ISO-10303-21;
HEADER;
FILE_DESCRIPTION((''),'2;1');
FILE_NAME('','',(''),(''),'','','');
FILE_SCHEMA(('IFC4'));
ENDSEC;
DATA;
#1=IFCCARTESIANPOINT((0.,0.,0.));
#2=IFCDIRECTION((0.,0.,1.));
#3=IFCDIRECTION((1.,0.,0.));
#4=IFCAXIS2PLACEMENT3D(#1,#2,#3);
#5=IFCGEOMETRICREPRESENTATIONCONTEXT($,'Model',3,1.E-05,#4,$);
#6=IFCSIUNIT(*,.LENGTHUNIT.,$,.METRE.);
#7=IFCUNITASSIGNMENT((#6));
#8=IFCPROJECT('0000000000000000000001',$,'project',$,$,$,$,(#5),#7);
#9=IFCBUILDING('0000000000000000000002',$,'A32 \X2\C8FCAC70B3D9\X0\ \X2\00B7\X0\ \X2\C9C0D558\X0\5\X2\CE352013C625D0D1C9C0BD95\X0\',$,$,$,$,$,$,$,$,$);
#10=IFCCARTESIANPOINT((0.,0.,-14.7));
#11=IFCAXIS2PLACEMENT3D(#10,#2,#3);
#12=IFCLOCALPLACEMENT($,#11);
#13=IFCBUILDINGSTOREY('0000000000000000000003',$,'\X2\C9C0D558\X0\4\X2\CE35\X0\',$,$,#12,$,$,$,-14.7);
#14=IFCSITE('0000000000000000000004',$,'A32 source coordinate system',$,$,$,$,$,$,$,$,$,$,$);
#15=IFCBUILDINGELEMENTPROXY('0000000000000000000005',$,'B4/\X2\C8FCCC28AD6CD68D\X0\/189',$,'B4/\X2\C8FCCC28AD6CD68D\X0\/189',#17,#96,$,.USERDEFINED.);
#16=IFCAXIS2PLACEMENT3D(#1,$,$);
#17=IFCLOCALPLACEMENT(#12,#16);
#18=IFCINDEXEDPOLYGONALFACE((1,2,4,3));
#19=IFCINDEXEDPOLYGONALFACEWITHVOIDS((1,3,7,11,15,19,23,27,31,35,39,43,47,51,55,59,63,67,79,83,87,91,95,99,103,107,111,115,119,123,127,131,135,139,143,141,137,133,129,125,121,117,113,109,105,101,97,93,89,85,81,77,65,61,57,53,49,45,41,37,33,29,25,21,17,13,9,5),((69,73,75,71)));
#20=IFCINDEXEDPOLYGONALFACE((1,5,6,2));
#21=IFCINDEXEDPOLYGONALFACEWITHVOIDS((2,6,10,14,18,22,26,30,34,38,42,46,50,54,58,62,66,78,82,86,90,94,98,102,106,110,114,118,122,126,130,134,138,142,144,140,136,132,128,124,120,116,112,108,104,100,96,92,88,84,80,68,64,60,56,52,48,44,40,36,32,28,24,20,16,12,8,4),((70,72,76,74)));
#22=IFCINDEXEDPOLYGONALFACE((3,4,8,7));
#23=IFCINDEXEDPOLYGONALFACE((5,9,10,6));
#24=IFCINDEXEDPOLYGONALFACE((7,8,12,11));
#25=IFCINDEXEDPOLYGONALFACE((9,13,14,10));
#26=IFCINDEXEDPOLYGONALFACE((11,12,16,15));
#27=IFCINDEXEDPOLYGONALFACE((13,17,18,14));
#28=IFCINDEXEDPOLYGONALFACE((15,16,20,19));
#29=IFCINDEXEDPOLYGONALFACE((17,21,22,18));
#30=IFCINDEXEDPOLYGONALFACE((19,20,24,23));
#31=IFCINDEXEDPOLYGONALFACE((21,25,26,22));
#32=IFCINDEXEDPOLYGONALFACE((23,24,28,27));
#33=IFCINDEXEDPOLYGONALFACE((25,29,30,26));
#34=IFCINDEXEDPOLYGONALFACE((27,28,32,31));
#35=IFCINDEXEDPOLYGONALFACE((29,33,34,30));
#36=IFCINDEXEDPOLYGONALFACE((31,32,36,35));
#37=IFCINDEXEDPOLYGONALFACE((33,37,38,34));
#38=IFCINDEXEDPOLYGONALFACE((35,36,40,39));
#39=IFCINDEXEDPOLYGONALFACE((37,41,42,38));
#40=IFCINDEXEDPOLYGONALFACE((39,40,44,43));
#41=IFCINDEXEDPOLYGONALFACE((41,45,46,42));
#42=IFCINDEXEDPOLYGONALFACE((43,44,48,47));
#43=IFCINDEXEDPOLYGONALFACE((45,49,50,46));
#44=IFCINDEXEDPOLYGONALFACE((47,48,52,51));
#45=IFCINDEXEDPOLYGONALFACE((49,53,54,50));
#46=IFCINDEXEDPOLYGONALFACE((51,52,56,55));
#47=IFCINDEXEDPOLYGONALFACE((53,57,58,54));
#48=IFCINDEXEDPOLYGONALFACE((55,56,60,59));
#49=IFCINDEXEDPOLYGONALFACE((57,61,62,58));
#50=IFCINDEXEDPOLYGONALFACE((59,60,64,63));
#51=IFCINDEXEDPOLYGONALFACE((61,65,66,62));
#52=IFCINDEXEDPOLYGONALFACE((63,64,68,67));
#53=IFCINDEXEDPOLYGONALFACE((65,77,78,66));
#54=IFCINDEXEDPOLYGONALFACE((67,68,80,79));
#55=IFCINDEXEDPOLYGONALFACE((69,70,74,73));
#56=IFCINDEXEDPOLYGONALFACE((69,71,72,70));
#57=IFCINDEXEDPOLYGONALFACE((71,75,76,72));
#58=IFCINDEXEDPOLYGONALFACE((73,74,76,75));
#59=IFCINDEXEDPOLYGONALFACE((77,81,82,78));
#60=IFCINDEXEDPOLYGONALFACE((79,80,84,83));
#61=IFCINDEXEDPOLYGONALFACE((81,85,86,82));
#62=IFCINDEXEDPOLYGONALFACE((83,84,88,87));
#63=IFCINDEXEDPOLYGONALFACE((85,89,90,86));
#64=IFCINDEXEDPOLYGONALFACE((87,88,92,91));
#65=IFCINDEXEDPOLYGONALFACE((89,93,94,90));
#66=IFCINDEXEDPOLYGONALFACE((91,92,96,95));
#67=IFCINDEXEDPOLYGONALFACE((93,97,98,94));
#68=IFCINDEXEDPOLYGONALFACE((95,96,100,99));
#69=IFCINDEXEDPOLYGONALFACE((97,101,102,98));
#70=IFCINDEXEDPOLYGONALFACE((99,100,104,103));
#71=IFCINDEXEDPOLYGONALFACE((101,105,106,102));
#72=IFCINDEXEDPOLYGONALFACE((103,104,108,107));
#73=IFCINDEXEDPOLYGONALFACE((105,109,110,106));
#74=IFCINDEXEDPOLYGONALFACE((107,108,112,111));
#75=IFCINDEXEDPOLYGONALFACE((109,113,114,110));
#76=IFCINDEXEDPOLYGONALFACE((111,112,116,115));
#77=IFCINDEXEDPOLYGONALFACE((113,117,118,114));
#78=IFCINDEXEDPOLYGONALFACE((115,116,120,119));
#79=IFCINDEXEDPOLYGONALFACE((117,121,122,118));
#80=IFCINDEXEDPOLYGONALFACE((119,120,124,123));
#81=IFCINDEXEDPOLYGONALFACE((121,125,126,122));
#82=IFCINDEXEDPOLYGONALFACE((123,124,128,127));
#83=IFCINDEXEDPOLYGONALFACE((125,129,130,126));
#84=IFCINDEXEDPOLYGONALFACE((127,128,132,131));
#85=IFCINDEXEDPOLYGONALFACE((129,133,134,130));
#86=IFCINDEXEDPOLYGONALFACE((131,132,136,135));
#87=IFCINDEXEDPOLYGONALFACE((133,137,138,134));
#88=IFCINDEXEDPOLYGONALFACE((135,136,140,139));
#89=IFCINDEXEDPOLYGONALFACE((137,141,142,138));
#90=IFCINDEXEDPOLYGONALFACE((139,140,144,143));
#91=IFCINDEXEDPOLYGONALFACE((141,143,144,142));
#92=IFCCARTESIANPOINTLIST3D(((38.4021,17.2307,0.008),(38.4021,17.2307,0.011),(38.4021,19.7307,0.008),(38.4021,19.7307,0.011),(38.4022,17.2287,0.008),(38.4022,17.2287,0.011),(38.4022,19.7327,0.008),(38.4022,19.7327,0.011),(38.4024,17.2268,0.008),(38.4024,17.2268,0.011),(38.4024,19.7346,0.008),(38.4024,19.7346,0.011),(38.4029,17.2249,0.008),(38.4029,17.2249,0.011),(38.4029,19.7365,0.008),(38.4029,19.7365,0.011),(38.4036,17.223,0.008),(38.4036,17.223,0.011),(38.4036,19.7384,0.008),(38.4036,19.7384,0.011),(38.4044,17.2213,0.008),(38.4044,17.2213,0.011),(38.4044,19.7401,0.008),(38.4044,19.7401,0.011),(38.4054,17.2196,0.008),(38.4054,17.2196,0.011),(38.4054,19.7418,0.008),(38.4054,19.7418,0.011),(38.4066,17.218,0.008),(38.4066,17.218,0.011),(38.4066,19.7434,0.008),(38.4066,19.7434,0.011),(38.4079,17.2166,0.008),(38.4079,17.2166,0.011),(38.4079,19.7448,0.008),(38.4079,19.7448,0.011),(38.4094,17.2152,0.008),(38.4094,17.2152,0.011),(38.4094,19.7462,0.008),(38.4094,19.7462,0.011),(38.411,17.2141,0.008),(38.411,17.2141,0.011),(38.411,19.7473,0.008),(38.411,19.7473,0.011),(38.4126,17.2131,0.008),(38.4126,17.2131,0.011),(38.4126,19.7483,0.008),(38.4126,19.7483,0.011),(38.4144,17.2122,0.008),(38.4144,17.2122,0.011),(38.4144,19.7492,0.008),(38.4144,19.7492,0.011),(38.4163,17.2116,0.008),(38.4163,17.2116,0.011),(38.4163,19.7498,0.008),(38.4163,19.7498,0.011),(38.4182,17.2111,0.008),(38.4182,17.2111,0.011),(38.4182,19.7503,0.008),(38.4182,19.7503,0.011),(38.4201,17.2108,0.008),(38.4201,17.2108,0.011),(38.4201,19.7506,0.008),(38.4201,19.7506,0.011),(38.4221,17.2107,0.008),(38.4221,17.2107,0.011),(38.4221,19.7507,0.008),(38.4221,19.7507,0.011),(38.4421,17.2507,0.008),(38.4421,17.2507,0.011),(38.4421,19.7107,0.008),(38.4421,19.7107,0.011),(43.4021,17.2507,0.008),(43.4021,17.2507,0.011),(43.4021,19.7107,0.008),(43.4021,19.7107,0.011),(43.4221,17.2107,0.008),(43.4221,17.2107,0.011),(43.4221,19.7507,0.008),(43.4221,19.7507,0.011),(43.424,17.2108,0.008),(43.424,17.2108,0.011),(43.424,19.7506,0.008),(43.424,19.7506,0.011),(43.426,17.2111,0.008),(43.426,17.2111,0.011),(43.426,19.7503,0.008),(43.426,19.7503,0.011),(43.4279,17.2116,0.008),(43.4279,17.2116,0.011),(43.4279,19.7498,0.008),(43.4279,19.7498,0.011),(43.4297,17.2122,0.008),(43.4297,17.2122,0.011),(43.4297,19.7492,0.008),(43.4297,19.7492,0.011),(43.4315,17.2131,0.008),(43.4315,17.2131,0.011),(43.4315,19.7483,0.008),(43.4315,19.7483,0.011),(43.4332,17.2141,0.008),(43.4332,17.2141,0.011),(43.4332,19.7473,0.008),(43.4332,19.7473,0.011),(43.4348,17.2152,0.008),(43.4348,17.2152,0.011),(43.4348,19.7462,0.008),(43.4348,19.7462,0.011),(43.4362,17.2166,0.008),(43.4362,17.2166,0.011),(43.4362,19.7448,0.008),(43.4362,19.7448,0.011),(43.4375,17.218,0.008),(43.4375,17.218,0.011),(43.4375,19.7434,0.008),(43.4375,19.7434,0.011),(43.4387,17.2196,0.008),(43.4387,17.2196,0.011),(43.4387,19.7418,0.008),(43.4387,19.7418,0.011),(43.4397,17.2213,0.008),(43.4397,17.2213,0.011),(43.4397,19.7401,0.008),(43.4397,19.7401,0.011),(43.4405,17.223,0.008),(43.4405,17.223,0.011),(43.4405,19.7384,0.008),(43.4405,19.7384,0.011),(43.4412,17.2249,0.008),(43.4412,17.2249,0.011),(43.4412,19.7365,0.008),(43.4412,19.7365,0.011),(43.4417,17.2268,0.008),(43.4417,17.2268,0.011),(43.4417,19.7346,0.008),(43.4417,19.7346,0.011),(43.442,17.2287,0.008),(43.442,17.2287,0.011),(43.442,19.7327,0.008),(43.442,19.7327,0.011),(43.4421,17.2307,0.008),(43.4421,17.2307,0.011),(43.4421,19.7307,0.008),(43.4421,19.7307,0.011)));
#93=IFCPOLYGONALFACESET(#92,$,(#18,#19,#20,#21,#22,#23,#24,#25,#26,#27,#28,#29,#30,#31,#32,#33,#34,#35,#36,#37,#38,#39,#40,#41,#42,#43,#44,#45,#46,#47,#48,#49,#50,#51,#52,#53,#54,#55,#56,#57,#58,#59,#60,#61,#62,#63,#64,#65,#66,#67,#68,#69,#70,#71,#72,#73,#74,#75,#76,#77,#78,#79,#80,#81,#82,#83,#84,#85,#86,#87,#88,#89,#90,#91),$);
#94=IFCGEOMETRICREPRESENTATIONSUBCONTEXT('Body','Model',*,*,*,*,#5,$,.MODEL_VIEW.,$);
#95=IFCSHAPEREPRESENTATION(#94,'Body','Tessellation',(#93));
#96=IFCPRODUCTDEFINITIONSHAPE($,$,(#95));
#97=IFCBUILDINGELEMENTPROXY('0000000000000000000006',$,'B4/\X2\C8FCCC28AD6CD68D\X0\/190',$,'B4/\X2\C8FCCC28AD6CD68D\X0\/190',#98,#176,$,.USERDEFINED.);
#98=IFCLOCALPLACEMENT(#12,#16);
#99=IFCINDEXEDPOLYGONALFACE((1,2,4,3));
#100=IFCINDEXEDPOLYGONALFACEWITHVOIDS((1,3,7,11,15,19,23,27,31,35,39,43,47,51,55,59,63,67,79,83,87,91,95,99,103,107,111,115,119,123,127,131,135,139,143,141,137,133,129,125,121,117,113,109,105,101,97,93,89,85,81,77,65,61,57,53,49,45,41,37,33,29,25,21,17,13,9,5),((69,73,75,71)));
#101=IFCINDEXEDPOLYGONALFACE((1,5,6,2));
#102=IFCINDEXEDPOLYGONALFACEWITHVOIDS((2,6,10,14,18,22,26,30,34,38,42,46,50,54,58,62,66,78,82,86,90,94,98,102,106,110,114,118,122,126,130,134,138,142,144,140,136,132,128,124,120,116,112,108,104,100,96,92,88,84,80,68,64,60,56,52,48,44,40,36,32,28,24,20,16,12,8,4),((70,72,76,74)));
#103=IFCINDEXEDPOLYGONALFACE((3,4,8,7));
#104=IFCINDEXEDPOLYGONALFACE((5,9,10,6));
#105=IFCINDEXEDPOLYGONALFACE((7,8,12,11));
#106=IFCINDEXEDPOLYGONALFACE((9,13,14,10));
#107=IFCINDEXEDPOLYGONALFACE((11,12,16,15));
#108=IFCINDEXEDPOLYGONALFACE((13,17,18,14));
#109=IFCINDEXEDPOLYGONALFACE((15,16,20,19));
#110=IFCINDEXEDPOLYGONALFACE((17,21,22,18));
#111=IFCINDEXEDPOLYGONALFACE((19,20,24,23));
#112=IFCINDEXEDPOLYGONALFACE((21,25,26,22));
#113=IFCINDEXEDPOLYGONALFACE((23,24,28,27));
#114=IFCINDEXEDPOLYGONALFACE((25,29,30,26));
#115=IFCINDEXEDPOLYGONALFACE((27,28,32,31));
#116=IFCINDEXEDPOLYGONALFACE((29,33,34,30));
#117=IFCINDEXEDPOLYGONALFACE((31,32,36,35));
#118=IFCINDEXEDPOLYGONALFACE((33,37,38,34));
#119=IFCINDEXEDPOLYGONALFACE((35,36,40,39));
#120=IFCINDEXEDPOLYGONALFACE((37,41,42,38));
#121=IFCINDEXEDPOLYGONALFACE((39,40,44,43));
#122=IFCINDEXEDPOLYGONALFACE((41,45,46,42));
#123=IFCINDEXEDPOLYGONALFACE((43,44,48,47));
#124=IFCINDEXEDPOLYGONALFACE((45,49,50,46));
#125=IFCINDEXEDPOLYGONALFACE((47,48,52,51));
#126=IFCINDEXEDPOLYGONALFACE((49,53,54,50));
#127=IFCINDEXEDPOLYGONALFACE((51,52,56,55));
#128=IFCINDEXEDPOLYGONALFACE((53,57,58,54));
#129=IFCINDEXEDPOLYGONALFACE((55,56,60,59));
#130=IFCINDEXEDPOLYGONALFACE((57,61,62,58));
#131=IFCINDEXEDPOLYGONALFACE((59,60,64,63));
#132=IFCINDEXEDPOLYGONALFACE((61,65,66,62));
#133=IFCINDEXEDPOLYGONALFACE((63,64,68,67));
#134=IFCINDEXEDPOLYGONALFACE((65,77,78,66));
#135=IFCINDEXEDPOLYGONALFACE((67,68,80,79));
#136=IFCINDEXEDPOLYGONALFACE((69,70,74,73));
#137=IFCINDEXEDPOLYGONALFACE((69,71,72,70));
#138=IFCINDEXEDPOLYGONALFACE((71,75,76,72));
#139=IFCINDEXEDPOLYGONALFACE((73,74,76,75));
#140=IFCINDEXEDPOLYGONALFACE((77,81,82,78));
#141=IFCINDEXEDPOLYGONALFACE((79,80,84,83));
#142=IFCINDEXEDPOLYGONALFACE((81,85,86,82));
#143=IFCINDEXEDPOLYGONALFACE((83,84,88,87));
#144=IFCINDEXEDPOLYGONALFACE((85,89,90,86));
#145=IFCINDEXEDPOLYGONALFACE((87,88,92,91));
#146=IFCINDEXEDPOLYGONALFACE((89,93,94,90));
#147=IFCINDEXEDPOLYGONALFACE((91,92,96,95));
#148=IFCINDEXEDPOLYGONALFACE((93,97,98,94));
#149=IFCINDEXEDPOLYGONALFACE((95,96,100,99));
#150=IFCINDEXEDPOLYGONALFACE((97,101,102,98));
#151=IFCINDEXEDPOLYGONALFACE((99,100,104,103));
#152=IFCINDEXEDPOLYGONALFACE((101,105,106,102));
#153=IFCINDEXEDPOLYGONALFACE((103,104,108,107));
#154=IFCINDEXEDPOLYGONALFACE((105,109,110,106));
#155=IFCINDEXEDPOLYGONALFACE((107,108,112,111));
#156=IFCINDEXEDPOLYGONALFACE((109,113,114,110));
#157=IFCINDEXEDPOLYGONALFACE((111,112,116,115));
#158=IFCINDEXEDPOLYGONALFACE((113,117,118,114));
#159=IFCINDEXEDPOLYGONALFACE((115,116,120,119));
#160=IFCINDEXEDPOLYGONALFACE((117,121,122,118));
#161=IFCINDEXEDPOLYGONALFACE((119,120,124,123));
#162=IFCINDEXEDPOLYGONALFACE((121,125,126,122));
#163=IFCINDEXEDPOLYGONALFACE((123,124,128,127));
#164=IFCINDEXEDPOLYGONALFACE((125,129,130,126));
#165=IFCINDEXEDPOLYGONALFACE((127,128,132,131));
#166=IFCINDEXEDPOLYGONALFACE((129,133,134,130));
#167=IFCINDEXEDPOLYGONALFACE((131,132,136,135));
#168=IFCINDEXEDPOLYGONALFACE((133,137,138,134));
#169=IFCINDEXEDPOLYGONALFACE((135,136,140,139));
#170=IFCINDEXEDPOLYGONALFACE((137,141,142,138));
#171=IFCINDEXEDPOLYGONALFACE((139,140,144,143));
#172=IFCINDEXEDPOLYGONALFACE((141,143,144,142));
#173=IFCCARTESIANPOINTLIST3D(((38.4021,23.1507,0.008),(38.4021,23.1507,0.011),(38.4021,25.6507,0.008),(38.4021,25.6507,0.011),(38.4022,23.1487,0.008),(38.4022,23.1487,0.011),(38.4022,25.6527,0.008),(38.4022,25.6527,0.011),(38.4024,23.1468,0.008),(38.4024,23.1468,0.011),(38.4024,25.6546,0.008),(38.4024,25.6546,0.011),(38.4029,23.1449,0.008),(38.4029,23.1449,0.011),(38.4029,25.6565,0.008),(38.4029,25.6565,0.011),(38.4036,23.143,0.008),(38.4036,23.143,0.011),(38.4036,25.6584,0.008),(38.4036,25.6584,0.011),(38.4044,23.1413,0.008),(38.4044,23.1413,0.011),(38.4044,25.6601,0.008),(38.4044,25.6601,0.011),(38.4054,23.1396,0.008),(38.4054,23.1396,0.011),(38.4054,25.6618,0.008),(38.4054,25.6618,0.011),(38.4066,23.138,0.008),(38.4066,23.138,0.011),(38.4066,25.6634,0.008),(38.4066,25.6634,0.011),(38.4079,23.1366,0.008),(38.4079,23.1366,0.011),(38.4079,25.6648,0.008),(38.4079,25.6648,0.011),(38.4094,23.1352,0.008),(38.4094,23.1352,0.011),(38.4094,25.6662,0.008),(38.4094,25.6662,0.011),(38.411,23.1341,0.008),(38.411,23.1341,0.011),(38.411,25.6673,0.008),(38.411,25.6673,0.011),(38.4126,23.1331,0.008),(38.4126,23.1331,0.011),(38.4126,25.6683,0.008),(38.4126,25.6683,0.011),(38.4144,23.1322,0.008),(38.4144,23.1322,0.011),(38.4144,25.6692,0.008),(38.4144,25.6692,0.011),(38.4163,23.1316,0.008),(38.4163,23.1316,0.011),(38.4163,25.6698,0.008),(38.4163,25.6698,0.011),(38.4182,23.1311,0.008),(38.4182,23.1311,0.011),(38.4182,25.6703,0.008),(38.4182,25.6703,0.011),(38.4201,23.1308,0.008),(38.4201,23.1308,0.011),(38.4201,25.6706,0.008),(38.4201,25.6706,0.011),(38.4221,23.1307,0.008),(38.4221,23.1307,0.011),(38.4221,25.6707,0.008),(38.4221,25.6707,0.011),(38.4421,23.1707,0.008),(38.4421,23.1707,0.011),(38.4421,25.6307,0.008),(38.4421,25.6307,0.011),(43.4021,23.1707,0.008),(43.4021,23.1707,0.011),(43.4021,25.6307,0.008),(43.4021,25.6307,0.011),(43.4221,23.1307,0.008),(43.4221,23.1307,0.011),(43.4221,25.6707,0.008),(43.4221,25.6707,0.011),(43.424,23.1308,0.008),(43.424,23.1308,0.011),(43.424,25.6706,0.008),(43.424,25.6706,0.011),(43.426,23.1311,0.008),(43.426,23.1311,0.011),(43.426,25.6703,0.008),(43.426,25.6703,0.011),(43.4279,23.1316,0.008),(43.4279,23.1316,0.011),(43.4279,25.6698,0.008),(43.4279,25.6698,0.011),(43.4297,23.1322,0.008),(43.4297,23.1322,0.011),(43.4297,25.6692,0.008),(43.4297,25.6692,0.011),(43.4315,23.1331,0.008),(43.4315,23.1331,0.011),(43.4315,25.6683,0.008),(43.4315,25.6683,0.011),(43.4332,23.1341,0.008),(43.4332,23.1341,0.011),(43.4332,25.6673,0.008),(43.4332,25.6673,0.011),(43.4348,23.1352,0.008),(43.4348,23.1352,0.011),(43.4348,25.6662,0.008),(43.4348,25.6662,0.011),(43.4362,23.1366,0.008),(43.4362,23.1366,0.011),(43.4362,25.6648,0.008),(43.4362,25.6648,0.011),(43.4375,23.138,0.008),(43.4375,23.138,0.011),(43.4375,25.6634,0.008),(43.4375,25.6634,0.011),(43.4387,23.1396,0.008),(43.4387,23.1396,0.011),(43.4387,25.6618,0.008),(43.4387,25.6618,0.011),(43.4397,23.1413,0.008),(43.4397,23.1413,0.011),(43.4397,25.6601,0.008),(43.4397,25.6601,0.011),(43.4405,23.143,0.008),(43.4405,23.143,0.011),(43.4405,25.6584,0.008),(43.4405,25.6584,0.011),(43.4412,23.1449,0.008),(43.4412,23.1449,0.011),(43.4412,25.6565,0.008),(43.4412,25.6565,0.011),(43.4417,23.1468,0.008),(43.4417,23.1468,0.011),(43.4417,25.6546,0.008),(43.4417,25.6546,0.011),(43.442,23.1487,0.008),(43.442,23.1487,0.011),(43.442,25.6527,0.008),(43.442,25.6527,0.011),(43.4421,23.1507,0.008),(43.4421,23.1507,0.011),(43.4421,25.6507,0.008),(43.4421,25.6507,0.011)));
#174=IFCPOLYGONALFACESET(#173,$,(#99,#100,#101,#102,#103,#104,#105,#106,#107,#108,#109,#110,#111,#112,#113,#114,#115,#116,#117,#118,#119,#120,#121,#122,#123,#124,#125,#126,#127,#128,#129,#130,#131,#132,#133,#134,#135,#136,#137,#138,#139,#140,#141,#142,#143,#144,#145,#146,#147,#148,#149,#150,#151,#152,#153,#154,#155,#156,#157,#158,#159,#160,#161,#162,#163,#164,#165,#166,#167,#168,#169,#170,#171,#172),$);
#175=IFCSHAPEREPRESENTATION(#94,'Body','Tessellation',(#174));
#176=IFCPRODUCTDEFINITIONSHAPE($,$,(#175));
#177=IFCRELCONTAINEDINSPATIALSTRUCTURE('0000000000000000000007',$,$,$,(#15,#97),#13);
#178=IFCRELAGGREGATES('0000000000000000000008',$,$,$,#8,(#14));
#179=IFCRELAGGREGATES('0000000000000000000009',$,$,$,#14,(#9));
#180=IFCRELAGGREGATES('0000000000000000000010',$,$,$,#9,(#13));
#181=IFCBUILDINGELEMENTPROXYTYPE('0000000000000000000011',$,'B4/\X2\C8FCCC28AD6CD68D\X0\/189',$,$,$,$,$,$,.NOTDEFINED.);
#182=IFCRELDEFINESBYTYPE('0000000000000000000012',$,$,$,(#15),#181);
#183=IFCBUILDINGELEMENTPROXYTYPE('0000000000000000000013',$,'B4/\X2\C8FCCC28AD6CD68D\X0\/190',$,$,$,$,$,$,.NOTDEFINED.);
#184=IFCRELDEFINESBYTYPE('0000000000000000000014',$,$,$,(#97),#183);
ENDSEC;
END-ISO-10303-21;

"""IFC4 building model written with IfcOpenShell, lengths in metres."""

from ifc_helpers import new_model, si_unit, frame, origin, origin_with_axes, place, context, subcontext, project, spatial, polyline, outline, extrude, source, transform, mapped, type_object, type_shapes, element, save


model = new_model("IFC4")

# Units and contexts
model_context = context("Model", 3, precision=1e-05, world=origin_with_axes())
body_context = subcontext(model_context, "Body", "Model", "MODEL_VIEW")
ifc_project = project(units=[si_unit("LENGTHUNIT", "METRE")], contexts=[model_context])

# Site, building, storey
site = spatial("IfcSite", under=ifc_project, Name="A32 source coordinate system")
building = spatial("IfcBuilding", under=site, Name="A32 주거동 · 지하5층–옥탑지붕")
storey_placement = place(None, frame((0.0, 0.0, -14.7), z_axis=(0.0, 0.0, 1.0), x_axis=(1.0, 0.0, 0.0)))
storey = spatial("IfcBuildingStorey", under=building, at=storey_placement, Name="지하4층", Elevation=-14.7)

# Building element proxies
building_element_proxy_type_1 = type_object("IfcBuildingElementProxyType", Name="B4/주차구획/189", PredefinedType="NOTDEFINED")
shared_shape_1 = source(origin(), body_context, "Body", "SweptSolid", [
    extrude(outline(polyline([(43.4221, 19.7507), (43.424, 19.7506), (43.426, 19.7503), (43.4279, 19.7498), (43.4297, 19.7492), (43.4315, 19.7483), (43.4332, 19.7473), (43.4348, 19.7462), (43.4362, 19.7448), (43.4375, 19.7434), (43.4387, 19.7418), (43.4397, 19.7401), (43.4405, 19.7384), (43.4412, 19.7365), (43.4417, 19.7346), (43.442, 19.7327), (43.4421, 19.7307), (43.4421, 17.2307), (43.442, 17.2287), (43.4417, 17.2268), (43.4412, 17.2249), (43.4405, 17.223), (43.4397, 17.2213), (43.4387, 17.2196), (43.4375, 17.218), (43.4362, 17.2166), (43.4348, 17.2152), (43.4332, 17.2141), (43.4315, 17.2131), (43.4297, 17.2122), (43.4279, 17.2116), (43.426, 17.2111), (43.424, 17.2108), (43.4221, 17.2107), (38.4221, 17.2107), (38.4201, 17.2108), (38.4182, 17.2111), (38.4163, 17.2116), (38.4144, 17.2122), (38.4126, 17.2131), (38.411, 17.2141), (38.4094, 17.2152), (38.4079, 17.2166), (38.4066, 17.218), (38.4054, 17.2196), (38.4044, 17.2213), (38.4036, 17.223), (38.4029, 17.2249), (38.4024, 17.2268), (38.4022, 17.2287), (38.4021, 17.2307), (38.4021, 19.7307), (38.4022, 19.7327), (38.4024, 19.7346), (38.4029, 19.7365), (38.4036, 19.7384), (38.4044, 19.7401), (38.4054, 19.7418), (38.4066, 19.7434), (38.4079, 19.7448), (38.4094, 19.7462), (38.411, 19.7473), (38.4126, 19.7483), (38.4144, 19.7492), (38.4163, 19.7498), (38.4182, 19.7503), (38.4201, 19.7506), (38.4221, 19.7507), (43.4221, 19.7507)]), holes=[polyline([(43.4021, 19.7107), (38.4421, 19.7107), (38.4421, 17.2507), (43.4021, 17.2507), (43.4021, 19.7107)])]), frame((0.0, 0.0, 0.008)), (0.0, 0.0, 1.0), 0.003),
])
type_shapes(building_element_proxy_type_1, [shared_shape_1])
proxy_1_placement = place(storey_placement, origin_with_axes())
element("IfcBuildingElementProxy", 1, at=proxy_1_placement, inside=storey, type_object=building_element_proxy_type_1, Name="B4/주차구획/189", ObjectType="B4/주차구획/189", PredefinedType="USERDEFINED", context=body_context, shape_type="MappedRepresentation", body=[
    mapped(shared_shape_1, transform((0.0, 0.0, 0.0), scale=1.0)),
])
building_element_proxy_type_2 = type_object("IfcBuildingElementProxyType", Name="B4/주차구획/190", PredefinedType="NOTDEFINED")
shared_shape_2 = source(origin(), body_context, "Body", "SweptSolid", [
    extrude(outline(polyline([(38.4221, 23.1307), (38.4201, 23.1308), (38.4182, 23.1311), (38.4163, 23.1316), (38.4144, 23.1322), (38.4126, 23.1331), (38.411, 23.1341), (38.4094, 23.1352), (38.4079, 23.1366), (38.4066, 23.138), (38.4054, 23.1396), (38.4044, 23.1413), (38.4036, 23.143), (38.4029, 23.1449), (38.4024, 23.1468), (38.4022, 23.1487), (38.4021, 23.1507), (38.4021, 25.6507), (38.4022, 25.6527), (38.4024, 25.6546), (38.4029, 25.6565), (38.4036, 25.6584), (38.4044, 25.6601), (38.4054, 25.6618), (38.4066, 25.6634), (38.4079, 25.6648), (38.4094, 25.6662), (38.411, 25.6673), (38.4126, 25.6683), (38.4144, 25.6692), (38.4163, 25.6698), (38.4182, 25.6703), (38.4201, 25.6706), (38.4221, 25.6707), (43.4221, 25.6707), (43.424, 25.6706), (43.426, 25.6703), (43.4279, 25.6698), (43.4297, 25.6692), (43.4315, 25.6683), (43.4332, 25.6673), (43.4348, 25.6662), (43.4362, 25.6648), (43.4375, 25.6634), (43.4387, 25.6618), (43.4397, 25.6601), (43.4405, 25.6584), (43.4412, 25.6565), (43.4417, 25.6546), (43.442, 25.6527), (43.4421, 25.6507), (43.4421, 23.1507), (43.442, 23.1487), (43.4417, 23.1468), (43.4412, 23.1449), (43.4405, 23.143), (43.4397, 23.1413), (43.4387, 23.1396), (43.4375, 23.138), (43.4362, 23.1366), (43.4348, 23.1352), (43.4332, 23.1341), (43.4315, 23.1331), (43.4297, 23.1322), (43.4279, 23.1316), (43.426, 23.1311), (43.424, 23.1308), (43.4221, 23.1307), (38.4221, 23.1307)]), holes=[polyline([(38.4421, 23.1707), (43.4021, 23.1707), (43.4021, 25.6307), (38.4421, 25.6307), (38.4421, 23.1707)])]), frame((0.0, 0.0, 0.008)), (0.0, 0.0, 1.0), 0.003),
])
type_shapes(building_element_proxy_type_2, [shared_shape_2])
proxy_2_placement = place(storey_placement, origin_with_axes())
element("IfcBuildingElementProxy", 2, at=proxy_2_placement, inside=storey, type_object=building_element_proxy_type_2, Name="B4/주차구획/190", ObjectType="B4/주차구획/190", PredefinedType="USERDEFINED", context=body_context, shape_type="MappedRepresentation", body=[
    mapped(shared_shape_2, transform((0.0, 0.0, 0.0), scale=1.0)),
])

save(model, "model.ifc")
